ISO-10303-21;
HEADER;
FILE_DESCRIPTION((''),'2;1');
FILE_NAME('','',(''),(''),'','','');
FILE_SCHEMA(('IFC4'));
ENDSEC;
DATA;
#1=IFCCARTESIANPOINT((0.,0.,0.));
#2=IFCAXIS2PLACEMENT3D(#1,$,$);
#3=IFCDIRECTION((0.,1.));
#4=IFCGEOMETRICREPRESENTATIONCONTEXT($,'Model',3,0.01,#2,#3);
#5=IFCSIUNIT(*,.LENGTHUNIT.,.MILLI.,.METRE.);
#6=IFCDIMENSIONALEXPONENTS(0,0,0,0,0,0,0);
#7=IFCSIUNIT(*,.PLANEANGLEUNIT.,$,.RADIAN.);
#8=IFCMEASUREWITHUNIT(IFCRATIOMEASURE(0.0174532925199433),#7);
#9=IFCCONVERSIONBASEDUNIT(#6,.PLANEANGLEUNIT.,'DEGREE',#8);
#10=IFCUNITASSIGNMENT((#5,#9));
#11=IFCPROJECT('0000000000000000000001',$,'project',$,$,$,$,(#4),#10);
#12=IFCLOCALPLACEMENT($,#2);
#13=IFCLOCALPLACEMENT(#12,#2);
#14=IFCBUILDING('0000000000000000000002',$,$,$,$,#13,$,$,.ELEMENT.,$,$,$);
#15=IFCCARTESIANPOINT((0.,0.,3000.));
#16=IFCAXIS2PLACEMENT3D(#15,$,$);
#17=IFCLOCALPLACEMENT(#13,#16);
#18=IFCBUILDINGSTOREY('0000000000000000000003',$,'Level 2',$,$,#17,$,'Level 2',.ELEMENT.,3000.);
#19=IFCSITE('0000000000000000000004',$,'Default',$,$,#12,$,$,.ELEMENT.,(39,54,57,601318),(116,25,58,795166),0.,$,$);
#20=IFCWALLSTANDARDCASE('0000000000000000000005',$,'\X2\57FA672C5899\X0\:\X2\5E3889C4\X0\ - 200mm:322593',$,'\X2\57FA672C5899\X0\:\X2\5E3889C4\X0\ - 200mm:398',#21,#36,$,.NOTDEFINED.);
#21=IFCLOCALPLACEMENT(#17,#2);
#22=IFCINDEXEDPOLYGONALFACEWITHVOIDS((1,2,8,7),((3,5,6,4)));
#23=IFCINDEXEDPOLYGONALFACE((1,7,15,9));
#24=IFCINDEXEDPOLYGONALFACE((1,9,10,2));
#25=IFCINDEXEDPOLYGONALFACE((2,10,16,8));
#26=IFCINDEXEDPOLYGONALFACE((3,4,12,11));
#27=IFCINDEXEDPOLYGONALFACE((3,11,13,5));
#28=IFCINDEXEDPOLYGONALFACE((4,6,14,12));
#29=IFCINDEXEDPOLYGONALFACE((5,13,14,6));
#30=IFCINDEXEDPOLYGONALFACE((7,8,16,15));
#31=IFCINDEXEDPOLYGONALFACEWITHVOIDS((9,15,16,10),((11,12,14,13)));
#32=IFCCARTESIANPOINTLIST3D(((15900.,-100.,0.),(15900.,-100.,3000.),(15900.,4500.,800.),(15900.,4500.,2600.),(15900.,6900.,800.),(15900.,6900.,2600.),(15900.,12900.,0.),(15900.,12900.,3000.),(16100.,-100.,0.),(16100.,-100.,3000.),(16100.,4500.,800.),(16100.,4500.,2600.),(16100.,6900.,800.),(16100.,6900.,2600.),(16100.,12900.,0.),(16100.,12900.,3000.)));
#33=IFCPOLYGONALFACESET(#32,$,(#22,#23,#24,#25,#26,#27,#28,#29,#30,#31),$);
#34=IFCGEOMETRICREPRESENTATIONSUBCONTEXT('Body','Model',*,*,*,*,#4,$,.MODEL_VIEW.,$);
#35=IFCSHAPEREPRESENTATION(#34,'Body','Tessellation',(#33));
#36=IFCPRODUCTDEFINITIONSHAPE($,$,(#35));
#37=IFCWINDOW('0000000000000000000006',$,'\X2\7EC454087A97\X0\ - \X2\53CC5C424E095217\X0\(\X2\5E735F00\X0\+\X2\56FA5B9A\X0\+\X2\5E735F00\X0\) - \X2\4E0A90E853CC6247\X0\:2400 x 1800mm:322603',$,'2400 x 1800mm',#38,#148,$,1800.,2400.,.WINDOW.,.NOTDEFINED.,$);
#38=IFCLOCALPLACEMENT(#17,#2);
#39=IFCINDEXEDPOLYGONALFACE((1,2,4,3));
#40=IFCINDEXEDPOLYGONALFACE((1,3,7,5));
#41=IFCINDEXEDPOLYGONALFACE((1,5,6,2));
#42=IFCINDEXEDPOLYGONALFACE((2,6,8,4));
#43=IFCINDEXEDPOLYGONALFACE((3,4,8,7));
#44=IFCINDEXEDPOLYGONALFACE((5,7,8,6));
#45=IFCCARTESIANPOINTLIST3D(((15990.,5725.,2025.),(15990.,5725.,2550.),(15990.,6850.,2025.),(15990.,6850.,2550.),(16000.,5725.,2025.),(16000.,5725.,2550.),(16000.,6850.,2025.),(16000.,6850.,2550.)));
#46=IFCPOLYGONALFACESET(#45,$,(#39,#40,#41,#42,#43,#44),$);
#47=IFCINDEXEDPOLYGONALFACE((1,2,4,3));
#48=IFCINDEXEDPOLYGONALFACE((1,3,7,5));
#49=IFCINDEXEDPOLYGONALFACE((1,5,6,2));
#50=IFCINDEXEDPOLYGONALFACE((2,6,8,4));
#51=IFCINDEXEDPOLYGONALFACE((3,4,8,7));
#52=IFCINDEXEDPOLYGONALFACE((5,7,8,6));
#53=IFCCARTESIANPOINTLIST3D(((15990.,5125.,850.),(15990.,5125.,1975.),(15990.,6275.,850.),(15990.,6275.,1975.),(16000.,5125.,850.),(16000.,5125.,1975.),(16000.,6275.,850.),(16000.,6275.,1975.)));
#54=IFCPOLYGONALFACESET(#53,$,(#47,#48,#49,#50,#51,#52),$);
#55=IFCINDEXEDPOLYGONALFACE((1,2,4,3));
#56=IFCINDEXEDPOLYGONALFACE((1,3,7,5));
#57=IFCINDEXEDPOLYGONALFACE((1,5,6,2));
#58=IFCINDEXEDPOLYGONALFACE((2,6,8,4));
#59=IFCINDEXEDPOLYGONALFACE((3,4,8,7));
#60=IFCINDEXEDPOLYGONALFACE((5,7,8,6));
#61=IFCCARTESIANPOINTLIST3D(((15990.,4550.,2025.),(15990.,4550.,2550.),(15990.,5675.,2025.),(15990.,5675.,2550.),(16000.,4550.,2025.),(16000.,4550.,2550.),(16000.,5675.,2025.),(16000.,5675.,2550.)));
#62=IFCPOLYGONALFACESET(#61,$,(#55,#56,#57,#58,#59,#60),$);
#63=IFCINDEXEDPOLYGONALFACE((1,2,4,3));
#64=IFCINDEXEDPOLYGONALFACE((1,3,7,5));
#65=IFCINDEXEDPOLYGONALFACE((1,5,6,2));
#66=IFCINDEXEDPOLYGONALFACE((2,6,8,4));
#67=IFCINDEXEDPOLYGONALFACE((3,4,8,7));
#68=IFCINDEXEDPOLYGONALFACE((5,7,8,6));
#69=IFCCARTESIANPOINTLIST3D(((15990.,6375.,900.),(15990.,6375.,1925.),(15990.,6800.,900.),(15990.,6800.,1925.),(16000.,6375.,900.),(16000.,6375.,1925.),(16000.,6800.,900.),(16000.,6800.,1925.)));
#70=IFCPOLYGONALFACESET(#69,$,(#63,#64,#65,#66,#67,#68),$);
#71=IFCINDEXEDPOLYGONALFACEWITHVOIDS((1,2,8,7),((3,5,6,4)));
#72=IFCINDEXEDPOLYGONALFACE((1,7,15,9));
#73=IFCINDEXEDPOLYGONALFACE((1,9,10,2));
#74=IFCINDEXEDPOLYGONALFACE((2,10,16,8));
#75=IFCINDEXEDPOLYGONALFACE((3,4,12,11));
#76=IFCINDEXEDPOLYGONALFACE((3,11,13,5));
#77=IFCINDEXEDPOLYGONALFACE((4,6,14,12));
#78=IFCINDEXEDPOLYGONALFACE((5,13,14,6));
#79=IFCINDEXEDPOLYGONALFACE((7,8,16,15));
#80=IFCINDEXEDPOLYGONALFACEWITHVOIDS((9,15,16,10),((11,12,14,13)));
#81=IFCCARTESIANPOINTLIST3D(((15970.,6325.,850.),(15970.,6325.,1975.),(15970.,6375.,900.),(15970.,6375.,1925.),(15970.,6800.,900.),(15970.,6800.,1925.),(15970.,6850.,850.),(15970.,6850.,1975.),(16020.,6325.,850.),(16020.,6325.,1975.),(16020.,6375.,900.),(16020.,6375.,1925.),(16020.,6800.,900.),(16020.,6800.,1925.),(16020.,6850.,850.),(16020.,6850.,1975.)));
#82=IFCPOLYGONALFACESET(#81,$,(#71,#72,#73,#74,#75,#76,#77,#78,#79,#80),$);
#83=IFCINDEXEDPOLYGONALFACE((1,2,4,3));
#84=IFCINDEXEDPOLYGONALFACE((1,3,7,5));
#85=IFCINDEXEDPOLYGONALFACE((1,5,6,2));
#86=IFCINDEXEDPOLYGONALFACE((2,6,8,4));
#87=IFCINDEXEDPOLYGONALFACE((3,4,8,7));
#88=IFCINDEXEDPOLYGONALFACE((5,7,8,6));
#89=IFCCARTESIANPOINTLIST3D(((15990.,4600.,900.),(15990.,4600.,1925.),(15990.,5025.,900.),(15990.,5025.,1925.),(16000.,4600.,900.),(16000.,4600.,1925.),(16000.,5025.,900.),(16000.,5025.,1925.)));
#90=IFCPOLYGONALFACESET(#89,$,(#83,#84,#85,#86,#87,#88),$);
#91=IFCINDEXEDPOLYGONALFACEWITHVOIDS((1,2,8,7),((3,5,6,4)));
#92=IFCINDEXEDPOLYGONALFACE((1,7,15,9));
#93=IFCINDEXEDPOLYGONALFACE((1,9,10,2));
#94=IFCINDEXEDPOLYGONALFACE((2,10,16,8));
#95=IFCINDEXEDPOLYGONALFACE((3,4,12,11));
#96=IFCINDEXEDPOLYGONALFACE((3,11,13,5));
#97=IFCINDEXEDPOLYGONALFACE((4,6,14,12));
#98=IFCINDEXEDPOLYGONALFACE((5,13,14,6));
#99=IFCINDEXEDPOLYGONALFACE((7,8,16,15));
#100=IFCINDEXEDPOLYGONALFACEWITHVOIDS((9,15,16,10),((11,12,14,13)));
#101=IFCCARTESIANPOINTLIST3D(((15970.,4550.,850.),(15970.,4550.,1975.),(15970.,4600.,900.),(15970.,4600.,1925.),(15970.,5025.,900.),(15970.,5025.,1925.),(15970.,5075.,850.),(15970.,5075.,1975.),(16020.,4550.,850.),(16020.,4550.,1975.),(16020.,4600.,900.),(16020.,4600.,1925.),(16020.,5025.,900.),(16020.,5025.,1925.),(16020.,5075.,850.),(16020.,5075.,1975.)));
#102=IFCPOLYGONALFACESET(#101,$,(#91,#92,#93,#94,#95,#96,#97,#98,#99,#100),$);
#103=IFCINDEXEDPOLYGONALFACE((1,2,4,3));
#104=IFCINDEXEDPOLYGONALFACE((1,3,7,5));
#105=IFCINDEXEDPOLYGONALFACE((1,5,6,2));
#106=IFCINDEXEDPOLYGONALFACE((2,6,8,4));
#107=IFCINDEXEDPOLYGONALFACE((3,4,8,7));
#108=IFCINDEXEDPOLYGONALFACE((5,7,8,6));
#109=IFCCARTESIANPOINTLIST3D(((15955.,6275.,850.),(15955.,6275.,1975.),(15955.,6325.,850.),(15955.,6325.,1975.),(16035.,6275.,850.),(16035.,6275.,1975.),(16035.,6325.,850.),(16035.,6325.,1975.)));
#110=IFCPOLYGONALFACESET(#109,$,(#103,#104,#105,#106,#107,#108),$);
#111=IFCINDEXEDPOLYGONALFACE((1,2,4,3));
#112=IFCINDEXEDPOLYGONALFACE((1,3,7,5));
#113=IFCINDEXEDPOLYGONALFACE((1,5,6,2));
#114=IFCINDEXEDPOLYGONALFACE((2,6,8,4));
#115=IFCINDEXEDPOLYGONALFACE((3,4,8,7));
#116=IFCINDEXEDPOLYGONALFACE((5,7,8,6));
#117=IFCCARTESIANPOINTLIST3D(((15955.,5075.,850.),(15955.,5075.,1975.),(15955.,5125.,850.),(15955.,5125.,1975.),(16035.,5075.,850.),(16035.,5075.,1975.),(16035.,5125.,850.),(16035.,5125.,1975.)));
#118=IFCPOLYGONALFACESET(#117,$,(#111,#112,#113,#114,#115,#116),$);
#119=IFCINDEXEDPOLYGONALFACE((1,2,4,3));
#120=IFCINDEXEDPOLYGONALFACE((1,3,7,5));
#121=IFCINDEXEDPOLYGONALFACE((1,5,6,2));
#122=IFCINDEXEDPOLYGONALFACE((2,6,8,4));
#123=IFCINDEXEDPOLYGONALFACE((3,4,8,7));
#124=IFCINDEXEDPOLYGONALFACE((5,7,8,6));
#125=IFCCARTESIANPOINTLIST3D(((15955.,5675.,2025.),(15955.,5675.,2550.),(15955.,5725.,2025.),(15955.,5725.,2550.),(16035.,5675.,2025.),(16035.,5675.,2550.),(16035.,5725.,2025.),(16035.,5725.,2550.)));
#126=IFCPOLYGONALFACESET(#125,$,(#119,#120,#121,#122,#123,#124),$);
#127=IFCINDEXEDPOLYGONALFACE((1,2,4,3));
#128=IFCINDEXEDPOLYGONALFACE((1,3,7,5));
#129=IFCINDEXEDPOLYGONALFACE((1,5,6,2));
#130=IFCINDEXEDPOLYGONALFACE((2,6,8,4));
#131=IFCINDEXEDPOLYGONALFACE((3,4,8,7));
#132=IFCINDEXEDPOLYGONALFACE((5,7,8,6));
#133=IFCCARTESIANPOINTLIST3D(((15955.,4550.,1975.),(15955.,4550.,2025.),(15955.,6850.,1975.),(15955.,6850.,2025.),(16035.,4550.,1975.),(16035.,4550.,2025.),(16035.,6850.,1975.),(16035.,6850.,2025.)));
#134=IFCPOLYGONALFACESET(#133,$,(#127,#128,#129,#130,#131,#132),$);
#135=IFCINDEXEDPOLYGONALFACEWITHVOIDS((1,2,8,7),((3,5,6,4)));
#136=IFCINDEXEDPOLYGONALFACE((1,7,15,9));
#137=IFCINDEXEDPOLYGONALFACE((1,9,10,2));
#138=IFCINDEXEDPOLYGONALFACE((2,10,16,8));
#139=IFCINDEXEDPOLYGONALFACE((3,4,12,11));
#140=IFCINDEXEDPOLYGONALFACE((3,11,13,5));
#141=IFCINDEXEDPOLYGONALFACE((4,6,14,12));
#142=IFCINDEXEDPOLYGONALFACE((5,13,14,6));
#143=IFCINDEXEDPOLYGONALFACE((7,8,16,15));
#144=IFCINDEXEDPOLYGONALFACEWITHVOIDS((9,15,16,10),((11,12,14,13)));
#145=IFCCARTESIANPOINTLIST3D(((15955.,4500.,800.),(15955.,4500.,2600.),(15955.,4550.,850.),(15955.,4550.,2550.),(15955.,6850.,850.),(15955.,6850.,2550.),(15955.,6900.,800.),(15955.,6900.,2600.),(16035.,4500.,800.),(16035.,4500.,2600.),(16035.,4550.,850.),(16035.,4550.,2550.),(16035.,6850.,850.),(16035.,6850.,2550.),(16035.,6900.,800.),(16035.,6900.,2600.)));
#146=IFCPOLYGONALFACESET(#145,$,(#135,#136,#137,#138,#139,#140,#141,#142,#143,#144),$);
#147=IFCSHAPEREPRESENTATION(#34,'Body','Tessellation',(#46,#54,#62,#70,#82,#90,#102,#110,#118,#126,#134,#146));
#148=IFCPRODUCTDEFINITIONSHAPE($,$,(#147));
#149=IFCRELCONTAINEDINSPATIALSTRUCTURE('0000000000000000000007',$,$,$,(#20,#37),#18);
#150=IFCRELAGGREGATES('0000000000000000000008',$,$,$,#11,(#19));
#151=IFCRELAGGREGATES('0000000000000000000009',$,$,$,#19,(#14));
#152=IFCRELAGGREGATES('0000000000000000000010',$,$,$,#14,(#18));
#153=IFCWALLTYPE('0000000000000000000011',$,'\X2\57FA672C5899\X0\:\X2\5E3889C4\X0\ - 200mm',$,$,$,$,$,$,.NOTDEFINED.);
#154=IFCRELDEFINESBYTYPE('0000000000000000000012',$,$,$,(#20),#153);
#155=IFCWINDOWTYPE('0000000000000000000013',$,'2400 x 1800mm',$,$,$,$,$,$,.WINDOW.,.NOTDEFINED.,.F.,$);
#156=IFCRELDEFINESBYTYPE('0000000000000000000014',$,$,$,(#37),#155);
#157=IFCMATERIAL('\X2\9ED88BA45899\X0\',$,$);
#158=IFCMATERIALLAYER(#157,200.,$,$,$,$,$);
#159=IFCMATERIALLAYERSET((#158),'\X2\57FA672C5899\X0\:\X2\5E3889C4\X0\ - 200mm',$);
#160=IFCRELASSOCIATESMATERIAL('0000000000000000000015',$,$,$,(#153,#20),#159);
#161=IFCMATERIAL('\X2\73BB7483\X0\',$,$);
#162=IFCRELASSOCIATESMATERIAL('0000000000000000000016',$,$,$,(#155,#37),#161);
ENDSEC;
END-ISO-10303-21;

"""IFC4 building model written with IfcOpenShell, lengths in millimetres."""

from ifc_helpers import new_model, entity, si_unit, converted_unit, direction, frame, frame_2d, origin, origin_2d_with_axis, place, context, subcontext, project, spatial, polyline, rectangle, outline, extrude, source, transform, mapped, material, layer, layer_set, layer_usage, type_object, type_shapes, element, fill, save


model = new_model("IFC4")

# Units and contexts
model_context = context("Model", 3, precision=0.01, world=origin(), true_north=direction((0.0, 1.0)))
body_context = subcontext(model_context, "Body", "Model", "MODEL_VIEW")
ifc_project = project(units=[si_unit("LENGTHUNIT", "METRE", prefix="MILLI"), converted_unit("PLANEANGLEUNIT", "DEGREE", entity("IfcRatioMeasure", 0.0174532925199433), si_unit("PLANEANGLEUNIT", "RADIAN"), dimensions=[0, 0, 0, 0, 0, 0, 0])], contexts=[model_context])

# Site, building, storey
site_placement = place(None, origin())
site = spatial("IfcSite", under=ifc_project, at=site_placement, Name="Default", CompositionType="ELEMENT", RefLatitude=(39, 54, 57, 601318), RefLongitude=(116, 25, 58, 795166), RefElevation=0.0)
building_placement = place(site_placement, origin())
building = spatial("IfcBuilding", under=site, at=building_placement, CompositionType="ELEMENT")
storey_placement = place(building_placement, frame((0.0, 0.0, 3000.0)))
storey = spatial("IfcBuildingStorey", under=building, at=storey_placement, Name="Level 2", LongName="Level 2", CompositionType="ELEMENT", Elevation=3000.0)

# Shared definitions
ifc_material_1 = material(Name="默认墙")
ifc_layer_1 = layer(ifc_material_1, 200.0)
ifc_layer_set_1 = layer_set([ifc_layer_1], Name="基本墙:常规 - 200mm")
wall_type = type_object("IfcWallType", Name="基本墙:常规 - 200mm", PredefinedType="NOTDEFINED", material=ifc_layer_set_1)

# Shared definitions
ifc_material_2 = material(Name="玻璃")

# Wall, opening, window
ifc_layer_usage_1 = layer_usage(ifc_layer_set_1, "AXIS2", "NEGATIVE", 100.0)
wall_1_placement = place(storey_placement, frame((16000.0, 12900.0, 0.0), z_axis=(0.0, 0.0, 1.0), x_axis=(0.0, -1.0, 0.0)))
wall_1 = element("IfcWallStandardCase", 1, at=wall_1_placement, inside=storey, type_object=wall_type, material=ifc_layer_usage_1, Name="基本墙:常规 - 200mm:322593", ObjectType="基本墙:常规 - 200mm:398", PredefinedType="NOTDEFINED", context=body_context, shape_type="SweptSolid", body=[
    extrude(rectangle(XDim=13000.0, YDim=200.0, at=frame_2d((6500.0, 0.0), x_axis=(-1.0, 0.0))), origin(), (0.0, 0.0, 1.0), 3000.0),
])
opening_1_placement = place(wall_1_placement, frame((6000.0, -100.0, 800.0)))
opening_1 = element("IfcOpeningElement", 2, at=opening_1_placement, cuts=wall_1, ObjectType="Opening", PredefinedType="OPENING", context=body_context, shape_type="SweptSolid", body=[
    extrude(rectangle(XDim=1800.0, YDim=2400.0, at=frame_2d((900.0, 1200.0), x_axis=(1.0, 0.0))), frame((0.0, 0.0, 0.0), z_axis=(0.0, 1.0, 0.0), x_axis=(0.0, 0.0, 1.0)), (0.0, 0.0, 1.0), 200.0),
])
window_type_1 = type_object("IfcWindowType", Name="2400 x 1800mm", ParameterTakesPrecedence=False, PartitioningType="NOTDEFINED", PredefinedType="WINDOW", material=ifc_material_2)
shared_shape_1 = source(origin(), body_context, "Body", "SweptSolid", [
    extrude(rectangle(XDim=10.0, YDim=1125.0, at=origin_2d_with_axis()), frame((612.5, 95.0, 1225.0), z_axis=(0.0, 0.0, 1.0), x_axis=(0.0, 1.0, 0.0)), (0.0, 0.0, 1.0), 525.0),
    extrude(rectangle(XDim=10.0, YDim=1150.0, at=origin_2d_with_axis()), frame((1200.0, 95.0, 50.0), z_axis=(0.0, 0.0, 1.0), x_axis=(0.0, 1.0, 0.0)), (0.0, 0.0, 1.0), 1125.0),
    extrude(rectangle(XDim=10.0, YDim=1125.0, at=origin_2d_with_axis()), frame((1787.5, 95.0, 1225.0), z_axis=(0.0, 0.0, 1.0), x_axis=(0.0, 1.0, 0.0)), (0.0, 0.0, 1.0), 525.0),
    extrude(rectangle(XDim=10.0, YDim=425.0, at=origin_2d_with_axis()), frame((312.5, 95.0, 100.0), z_axis=(0.0, 0.0, 1.0), x_axis=(0.0, 1.0, 0.0)), (0.0, 0.0, 1.0), 1025.0),
    extrude(outline(polyline([(-562.5, -262.5), (562.5, -262.5), (562.5, 262.5), (-562.5, 262.5), (-562.5, -262.5)]), holes=[polyline([(512.5, -212.5), (-512.5, -212.5), (-512.5, 212.5), (512.5, 212.5), (512.5, -212.5)])]), frame((312.5, 70.0, 612.5), z_axis=(0.0, 1.0, 0.0), x_axis=(0.0, 0.0, -1.0)), (0.0, 0.0, 1.0), 50.0),
    extrude(rectangle(XDim=10.0, YDim=425.0, at=frame_2d((0.0, 0.0), x_axis=(1.0, 0.0))), frame((2087.5, 95.0, 100.0), z_axis=(0.0, 0.0, 1.0), x_axis=(0.0, 1.0, 0.0)), (0.0, 0.0, 1.0), 1025.0),
    extrude(outline(polyline([(-562.5, -262.5), (562.5, -262.5), (562.5, 262.5), (-562.5, 262.5), (-562.5, -262.5)]), holes=[polyline([(512.5, -212.5), (-512.5, -212.5), (-512.5, 212.5), (512.5, 212.5), (512.5, -212.5)])]), frame((2087.5, 70.0, 612.5), z_axis=(0.0, 1.0, 0.0), x_axis=(0.0, 0.0, -1.0)), (0.0, 0.0, 1.0), 50.0),
    extrude(rectangle(XDim=80.0, YDim=50.0, at=origin_2d_with_axis()), frame((600.0, 95.0, 50.0), z_axis=(0.0, 0.0, 1.0), x_axis=(0.0, -1.0, 0.0)), (0.0, 0.0, 1.0), 1125.0),
    extrude(rectangle(XDim=80.0, YDim=50.0, at=origin_2d_with_axis()), frame((1800.0, 95.0, 50.0), z_axis=(0.0, 0.0, 1.0), x_axis=(0.0, -1.0, 0.0)), (0.0, 0.0, 1.0), 1125.0),
    extrude(rectangle(XDim=80.0, YDim=50.0, at=frame_2d((0.0, 0.0), x_axis=(1.0, 0.0))), frame((1200.0, 95.0, 1225.0), z_axis=(0.0, 0.0, 1.0), x_axis=(0.0, -1.0, 0.0)), (0.0, 0.0, 1.0), 525.0),
    extrude(rectangle(XDim=80.0, YDim=2300.0, at=frame_2d((0.0, 0.0), x_axis=(1.0, 0.0))), frame((1200.0, 95.0, 1175.0), z_axis=(0.0, 0.0, 1.0), x_axis=(0.0, -1.0, 0.0)), (0.0, 0.0, 1.0), 50.0),
    extrude(outline(polyline([(-1200.0, -900.0), (1200.0, -900.0), (1200.0, 900.0), (-1200.0, 900.0), (-1200.0, -900.0)]), holes=[polyline([(1150.0, -850.0), (-1150.0, -850.0), (-1150.0, 850.0), (1150.0, 850.0), (1150.0, -850.0)])]), frame((1200.0, 55.0, 900.0), z_axis=(0.0, 1.0, 0.0), x_axis=(1.0, 0.0, 0.0)), (0.0, 0.0, 1.0), 80.0),
])
type_shapes(window_type_1, [shared_shape_1])
window_1_placement = place(opening_1_placement, origin())
window_1 = element("IfcWindow", 3, at=window_1_placement, inside=storey, type_object=window_type_1, material=ifc_material_2, Name="组合窗 - 双层三列(平开+固定+平开) - 上部双扇:2400 x 1800mm:322603", ObjectType="2400 x 1800mm", OverallHeight=1800.0, OverallWidth=2400.0, PartitioningType="NOTDEFINED", PredefinedType="WINDOW", context=body_context, shape_type="MappedRepresentation", body=[
    mapped(shared_shape_1, transform((0.0, 0.0, 0.0), scale=1.0)),
])
fill(opening_1, window_1)

save(model, "model.ifc")
